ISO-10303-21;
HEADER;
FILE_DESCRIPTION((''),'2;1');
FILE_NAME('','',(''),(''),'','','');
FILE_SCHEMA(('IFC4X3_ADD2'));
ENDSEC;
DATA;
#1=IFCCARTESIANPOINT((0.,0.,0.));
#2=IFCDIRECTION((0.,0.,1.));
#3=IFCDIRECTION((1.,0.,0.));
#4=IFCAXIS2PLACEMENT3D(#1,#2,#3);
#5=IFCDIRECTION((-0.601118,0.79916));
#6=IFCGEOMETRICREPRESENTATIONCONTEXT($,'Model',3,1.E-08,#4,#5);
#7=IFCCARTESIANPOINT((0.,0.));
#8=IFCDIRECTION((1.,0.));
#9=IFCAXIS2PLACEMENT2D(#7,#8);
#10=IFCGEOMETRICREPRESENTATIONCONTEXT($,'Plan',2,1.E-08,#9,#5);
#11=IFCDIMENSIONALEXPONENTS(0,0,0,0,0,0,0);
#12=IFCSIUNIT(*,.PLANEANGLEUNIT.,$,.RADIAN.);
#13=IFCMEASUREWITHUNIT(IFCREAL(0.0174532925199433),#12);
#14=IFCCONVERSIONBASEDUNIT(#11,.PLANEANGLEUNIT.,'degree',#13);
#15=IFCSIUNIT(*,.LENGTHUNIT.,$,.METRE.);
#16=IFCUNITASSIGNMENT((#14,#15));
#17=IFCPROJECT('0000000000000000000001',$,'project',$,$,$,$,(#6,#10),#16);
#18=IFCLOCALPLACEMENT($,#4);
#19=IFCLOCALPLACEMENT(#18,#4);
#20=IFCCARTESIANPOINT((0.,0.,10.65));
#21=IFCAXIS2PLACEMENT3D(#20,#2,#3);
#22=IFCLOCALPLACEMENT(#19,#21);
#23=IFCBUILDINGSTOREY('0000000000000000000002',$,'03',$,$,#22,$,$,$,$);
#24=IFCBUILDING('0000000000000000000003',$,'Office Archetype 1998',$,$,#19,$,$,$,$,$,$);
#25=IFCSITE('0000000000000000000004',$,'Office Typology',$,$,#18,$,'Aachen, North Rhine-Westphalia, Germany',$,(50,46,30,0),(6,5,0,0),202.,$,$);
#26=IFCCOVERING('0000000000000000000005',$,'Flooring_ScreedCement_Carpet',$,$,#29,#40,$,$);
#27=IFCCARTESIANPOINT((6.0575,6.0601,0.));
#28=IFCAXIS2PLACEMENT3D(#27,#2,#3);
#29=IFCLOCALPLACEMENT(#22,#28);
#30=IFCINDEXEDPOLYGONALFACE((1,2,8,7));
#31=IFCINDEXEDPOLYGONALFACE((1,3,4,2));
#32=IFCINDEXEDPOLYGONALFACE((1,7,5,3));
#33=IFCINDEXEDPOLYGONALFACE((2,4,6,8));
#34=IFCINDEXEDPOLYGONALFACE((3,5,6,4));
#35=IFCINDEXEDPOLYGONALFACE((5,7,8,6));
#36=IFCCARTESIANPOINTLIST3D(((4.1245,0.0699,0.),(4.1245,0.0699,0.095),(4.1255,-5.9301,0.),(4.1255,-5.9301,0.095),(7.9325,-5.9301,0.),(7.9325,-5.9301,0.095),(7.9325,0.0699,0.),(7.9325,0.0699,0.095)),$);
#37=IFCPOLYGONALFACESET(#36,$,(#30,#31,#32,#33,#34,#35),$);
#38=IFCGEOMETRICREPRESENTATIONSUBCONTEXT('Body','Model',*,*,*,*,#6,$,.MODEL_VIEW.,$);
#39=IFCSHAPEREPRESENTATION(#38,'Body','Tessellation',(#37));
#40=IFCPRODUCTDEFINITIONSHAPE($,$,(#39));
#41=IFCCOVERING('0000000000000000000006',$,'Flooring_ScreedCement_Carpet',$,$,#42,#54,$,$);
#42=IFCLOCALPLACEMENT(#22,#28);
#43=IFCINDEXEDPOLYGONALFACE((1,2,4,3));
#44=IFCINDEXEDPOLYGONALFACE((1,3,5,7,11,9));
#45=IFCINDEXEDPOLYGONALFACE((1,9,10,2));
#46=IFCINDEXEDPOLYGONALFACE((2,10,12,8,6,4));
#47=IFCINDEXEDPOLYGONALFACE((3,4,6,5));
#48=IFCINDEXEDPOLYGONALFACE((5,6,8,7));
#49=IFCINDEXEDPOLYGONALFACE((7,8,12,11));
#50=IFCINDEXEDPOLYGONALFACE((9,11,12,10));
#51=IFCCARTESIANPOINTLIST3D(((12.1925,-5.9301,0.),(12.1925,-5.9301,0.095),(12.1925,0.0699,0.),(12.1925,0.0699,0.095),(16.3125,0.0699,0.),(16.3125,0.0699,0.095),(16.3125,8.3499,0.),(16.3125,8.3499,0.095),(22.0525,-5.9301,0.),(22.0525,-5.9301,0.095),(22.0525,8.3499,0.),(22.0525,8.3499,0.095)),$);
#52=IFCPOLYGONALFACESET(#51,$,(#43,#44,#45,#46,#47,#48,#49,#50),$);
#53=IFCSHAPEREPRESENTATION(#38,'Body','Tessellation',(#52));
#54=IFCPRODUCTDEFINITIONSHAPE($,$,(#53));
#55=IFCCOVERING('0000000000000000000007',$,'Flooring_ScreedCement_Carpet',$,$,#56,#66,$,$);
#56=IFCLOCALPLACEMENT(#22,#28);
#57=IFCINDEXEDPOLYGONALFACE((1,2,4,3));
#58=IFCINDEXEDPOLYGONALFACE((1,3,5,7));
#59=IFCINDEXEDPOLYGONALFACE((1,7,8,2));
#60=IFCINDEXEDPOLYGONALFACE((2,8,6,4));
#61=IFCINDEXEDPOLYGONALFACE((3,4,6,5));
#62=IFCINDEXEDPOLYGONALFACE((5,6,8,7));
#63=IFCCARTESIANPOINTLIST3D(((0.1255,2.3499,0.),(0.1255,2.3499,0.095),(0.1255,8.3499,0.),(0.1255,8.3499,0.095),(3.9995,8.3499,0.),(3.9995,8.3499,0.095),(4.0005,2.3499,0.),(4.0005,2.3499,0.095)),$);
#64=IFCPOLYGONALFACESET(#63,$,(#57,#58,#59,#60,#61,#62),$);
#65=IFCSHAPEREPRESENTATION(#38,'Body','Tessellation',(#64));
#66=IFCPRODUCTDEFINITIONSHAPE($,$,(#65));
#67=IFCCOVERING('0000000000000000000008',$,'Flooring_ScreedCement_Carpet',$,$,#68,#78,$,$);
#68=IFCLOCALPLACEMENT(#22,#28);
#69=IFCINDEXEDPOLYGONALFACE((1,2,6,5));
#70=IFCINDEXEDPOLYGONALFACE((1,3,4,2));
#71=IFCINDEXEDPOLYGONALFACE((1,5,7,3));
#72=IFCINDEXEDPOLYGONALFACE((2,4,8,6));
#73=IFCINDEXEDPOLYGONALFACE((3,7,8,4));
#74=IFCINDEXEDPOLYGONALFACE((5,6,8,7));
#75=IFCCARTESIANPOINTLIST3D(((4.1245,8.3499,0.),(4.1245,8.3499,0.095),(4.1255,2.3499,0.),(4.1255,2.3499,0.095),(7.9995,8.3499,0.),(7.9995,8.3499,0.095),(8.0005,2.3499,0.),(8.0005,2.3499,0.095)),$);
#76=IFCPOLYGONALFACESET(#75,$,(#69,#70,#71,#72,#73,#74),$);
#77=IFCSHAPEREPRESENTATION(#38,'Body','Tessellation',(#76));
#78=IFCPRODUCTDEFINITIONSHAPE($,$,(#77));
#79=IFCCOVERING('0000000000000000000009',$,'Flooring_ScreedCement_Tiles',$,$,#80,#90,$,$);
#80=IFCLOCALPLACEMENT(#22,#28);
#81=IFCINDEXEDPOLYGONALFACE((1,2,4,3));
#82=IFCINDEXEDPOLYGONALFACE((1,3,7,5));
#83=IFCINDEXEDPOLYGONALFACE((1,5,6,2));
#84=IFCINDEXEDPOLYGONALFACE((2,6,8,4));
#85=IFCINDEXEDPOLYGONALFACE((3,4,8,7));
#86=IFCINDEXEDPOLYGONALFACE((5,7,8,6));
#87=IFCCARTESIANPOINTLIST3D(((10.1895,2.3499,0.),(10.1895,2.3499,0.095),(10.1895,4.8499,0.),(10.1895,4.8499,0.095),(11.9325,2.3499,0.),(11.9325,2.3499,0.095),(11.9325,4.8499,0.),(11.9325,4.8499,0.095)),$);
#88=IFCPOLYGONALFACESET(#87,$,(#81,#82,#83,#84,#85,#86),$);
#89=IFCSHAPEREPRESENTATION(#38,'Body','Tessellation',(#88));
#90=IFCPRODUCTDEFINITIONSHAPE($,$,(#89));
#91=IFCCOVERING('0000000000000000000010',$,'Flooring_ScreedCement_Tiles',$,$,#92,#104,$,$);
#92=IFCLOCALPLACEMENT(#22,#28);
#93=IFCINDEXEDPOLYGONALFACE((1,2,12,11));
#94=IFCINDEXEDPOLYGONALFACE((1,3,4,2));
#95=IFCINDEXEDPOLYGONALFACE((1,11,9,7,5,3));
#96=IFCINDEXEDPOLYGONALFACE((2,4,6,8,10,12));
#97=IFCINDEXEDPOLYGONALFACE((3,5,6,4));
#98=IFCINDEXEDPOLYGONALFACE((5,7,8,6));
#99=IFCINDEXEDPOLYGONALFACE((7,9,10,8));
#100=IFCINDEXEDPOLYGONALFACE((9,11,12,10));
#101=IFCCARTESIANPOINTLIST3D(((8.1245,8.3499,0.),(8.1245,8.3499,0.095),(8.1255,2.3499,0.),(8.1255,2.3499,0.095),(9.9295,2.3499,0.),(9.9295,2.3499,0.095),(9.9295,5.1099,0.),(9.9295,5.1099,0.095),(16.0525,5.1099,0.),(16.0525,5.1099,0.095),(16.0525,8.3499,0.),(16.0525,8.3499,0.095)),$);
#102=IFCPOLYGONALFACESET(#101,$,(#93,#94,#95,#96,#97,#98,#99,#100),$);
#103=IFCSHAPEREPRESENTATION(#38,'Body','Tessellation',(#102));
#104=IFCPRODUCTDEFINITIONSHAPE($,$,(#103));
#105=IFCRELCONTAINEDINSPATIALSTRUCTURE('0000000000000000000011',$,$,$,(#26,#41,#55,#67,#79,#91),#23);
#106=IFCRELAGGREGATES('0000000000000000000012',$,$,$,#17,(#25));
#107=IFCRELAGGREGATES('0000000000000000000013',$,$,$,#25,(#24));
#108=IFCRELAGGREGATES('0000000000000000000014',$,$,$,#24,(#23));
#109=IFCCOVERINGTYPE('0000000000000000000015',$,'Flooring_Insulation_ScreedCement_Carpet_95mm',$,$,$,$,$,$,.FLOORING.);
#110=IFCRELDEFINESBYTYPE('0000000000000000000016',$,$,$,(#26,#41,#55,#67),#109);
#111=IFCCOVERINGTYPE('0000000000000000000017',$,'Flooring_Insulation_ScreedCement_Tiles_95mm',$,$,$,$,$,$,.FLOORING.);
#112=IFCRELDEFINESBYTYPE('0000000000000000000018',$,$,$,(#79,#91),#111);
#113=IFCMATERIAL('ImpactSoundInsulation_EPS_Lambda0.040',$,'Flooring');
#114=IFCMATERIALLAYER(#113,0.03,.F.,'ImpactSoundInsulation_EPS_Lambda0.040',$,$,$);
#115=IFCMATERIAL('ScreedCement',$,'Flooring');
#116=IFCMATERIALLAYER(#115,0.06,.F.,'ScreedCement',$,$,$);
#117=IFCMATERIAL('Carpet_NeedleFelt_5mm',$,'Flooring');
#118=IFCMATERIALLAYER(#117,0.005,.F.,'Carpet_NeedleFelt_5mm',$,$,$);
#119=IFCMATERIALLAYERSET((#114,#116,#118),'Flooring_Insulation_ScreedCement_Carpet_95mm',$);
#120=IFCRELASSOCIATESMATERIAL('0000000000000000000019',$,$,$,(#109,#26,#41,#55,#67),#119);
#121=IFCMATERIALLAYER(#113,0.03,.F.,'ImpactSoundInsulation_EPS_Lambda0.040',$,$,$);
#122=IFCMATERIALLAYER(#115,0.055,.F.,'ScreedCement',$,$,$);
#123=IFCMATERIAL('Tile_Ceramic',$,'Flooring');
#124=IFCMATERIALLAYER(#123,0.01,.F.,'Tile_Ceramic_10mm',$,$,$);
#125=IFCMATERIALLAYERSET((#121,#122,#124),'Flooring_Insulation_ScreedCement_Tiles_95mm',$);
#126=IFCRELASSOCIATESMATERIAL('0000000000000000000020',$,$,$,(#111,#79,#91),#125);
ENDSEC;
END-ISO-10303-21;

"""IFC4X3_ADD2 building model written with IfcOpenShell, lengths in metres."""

from ifc_helpers import new_model, entity, si_unit, converted_unit, direction, frame, origin_with_axes, origin_2d_with_axis, place, context, subcontext, project, spatial, line, indexed_curve, outline, extrude, material, layer, layer_set, layer_usage, type_object, element, save


model = new_model("IFC4X3_ADD2")

# Units and contexts
model_context = context("Model", 3, precision=1e-08, world=origin_with_axes(), true_north=direction((-0.601118, 0.79916)))
plan_context = context("Plan", 2, precision=1e-08, world=origin_2d_with_axis(), true_north=direction((-0.601118, 0.79916)))
body_context = subcontext(model_context, "Body", "Model", "MODEL_VIEW")
ifc_project = project(units=[converted_unit("PLANEANGLEUNIT", "degree", entity("IfcReal", 0.0174532925199433), si_unit("PLANEANGLEUNIT", "RADIAN"), dimensions=[0, 0, 0, 0, 0, 0, 0]), si_unit("LENGTHUNIT", "METRE")], contexts=[model_context, plan_context])

# Site, building, storey
site_placement = place(None, origin_with_axes())
site = spatial("IfcSite", under=ifc_project, at=site_placement, Name="Office Typology", LongName="Aachen, North Rhine-Westphalia, Germany", RefLatitude=(50, 46, 30, 0), RefLongitude=(6, 5, 0, 0), RefElevation=202.0)
building_placement = place(site_placement, origin_with_axes())
building = spatial("IfcBuilding", under=site, at=building_placement, Name="Office Archetype 1998")
storey_placement = place(building_placement, frame((0.0, 0.0, 10.65), z_axis=(0.0, 0.0, 1.0), x_axis=(1.0, 0.0, 0.0)))
storey = spatial("IfcBuildingStorey", under=building, at=storey_placement, Name="03")

# Coverings
ifc_material_1 = material(Name="ImpactSoundInsulation_EPS_Lambda0.040", Category="Flooring")
ifc_layer_1 = layer(ifc_material_1, 0.03, ventilated=False, Name="ImpactSoundInsulation_EPS_Lambda0.040")
ifc_material_2 = material(Name="ScreedCement", Category="Flooring")
ifc_layer_2 = layer(ifc_material_2, 0.06, ventilated=False, Name="ScreedCement")
ifc_material_3 = material(Name="Carpet_NeedleFelt_5mm", Category="Flooring")
ifc_layer_3 = layer(ifc_material_3, 0.005, ventilated=False, Name="Carpet_NeedleFelt_5mm")
ifc_layer_set_1 = layer_set([ifc_layer_1, ifc_layer_2, ifc_layer_3], Name="Flooring_Insulation_ScreedCement_Carpet_95mm")
ifc_layer_usage_1 = layer_usage(ifc_layer_set_1, "AXIS3", "POSITIVE", 0.0)
covering_type_1 = type_object("IfcCoveringType", Name="Flooring_Insulation_ScreedCement_Carpet_95mm", PredefinedType="FLOORING", material=ifc_layer_set_1)
covering_1_placement = place(storey_placement, frame((6.0575, 6.0601, 0.0), z_axis=(0.0, 0.0, 1.0), x_axis=(1.0, 0.0, 0.0)))
element("IfcCovering", 1, at=covering_1_placement, inside=storey, type_object=covering_type_1, material=ifc_layer_usage_1, Name="Flooring_ScreedCement_Carpet", context=body_context, shape_type="SweptSolid", body=[
    extrude(outline(indexed_curve([(4.1245, 0.0699), (7.9325, 0.0699), (7.9325, -5.9301), (4.1255, -5.9301)], segments=[line(1, 2, 3, 4, 1)])), origin_with_axes(), (0.0, 0.0, 1.0), 0.095),
])
ifc_layer_usage_2 = layer_usage(ifc_layer_set_1, "AXIS3", "POSITIVE", 0.0)
covering_2_placement = place(storey_placement, frame((6.0575, 6.0601, 0.0), z_axis=(0.0, 0.0, 1.0), x_axis=(1.0, 0.0, 0.0)))
element("IfcCovering", 2, at=covering_2_placement, inside=storey, type_object=covering_type_1, material=ifc_layer_usage_2, Name="Flooring_ScreedCement_Carpet", context=body_context, shape_type="SweptSolid", body=[
    extrude(outline(indexed_curve([(16.3125, 8.3499), (22.0525, 8.3499), (22.0525, -5.9301), (12.1925, -5.9301), (12.1925, 0.0699), (16.3125, 0.0699)], segments=[line(1, 2, 3, 4, 5, 6, 1)])), origin_with_axes(), (0.0, 0.0, 1.0), 0.095),
])
ifc_layer_usage_3 = layer_usage(ifc_layer_set_1, "AXIS3", "POSITIVE", 0.0)
covering_3_placement = place(storey_placement, frame((6.0575, 6.0601, 0.0), z_axis=(0.0, 0.0, 1.0), x_axis=(1.0, 0.0, 0.0)))
element("IfcCovering", 3, at=covering_3_placement, inside=storey, type_object=covering_type_1, material=ifc_layer_usage_3, Name="Flooring_ScreedCement_Carpet", context=body_context, shape_type="SweptSolid", body=[
    extrude(outline(indexed_curve([(0.1255, 2.3499), (0.1255, 8.3499), (3.9995, 8.3499), (4.0005, 2.3499)], segments=[line(1, 2, 3, 4, 1)])), origin_with_axes(), (0.0, 0.0, 1.0), 0.095),
])
ifc_layer_usage_4 = layer_usage(ifc_layer_set_1, "AXIS3", "POSITIVE", 0.0)
covering_4_placement = place(storey_placement, frame((6.0575, 6.0601, 0.0), z_axis=(0.0, 0.0, 1.0), x_axis=(1.0, 0.0, 0.0)))
element("IfcCovering", 4, at=covering_4_placement, inside=storey, type_object=covering_type_1, material=ifc_layer_usage_4, Name="Flooring_ScreedCement_Carpet", context=body_context, shape_type="SweptSolid", body=[
    extrude(outline(indexed_curve([(4.1255, 2.3499), (4.1245, 8.3499), (7.9995, 8.3499), (8.0005, 2.3499)], segments=[line(1, 2, 3, 4, 1)])), origin_with_axes(), (0.0, 0.0, 1.0), 0.095),
])
ifc_layer_4 = layer(ifc_material_1, 0.03, ventilated=False, Name="ImpactSoundInsulation_EPS_Lambda0.040")
ifc_layer_5 = layer(ifc_material_2, 0.055, ventilated=False, Name="ScreedCement")
ifc_material_4 = material(Name="Tile_Ceramic", Category="Flooring")
ifc_layer_6 = layer(ifc_material_4, 0.01, ventilated=False, Name="Tile_Ceramic_10mm")
ifc_layer_set_2 = layer_set([ifc_layer_4, ifc_layer_5, ifc_layer_6], Name="Flooring_Insulation_ScreedCement_Tiles_95mm")
ifc_layer_usage_5 = layer_usage(ifc_layer_set_2, "AXIS3", "POSITIVE", 0.0)
covering_type_2 = type_object("IfcCoveringType", Name="Flooring_Insulation_ScreedCement_Tiles_95mm", PredefinedType="FLOORING", material=ifc_layer_set_2)
covering_5_placement = place(storey_placement, frame((6.0575, 6.0601, 0.0), z_axis=(0.0, 0.0, 1.0), x_axis=(1.0, 0.0, 0.0)))
element("IfcCovering", 5, at=covering_5_placement, inside=storey, type_object=covering_type_2, material=ifc_layer_usage_5, Name="Flooring_ScreedCement_Tiles", context=body_context, shape_type="SweptSolid", body=[
    extrude(outline(indexed_curve([(11.9325, 4.8499), (11.9325, 2.3499), (10.1895, 2.3499), (10.1895, 4.8499)], segments=[line(1, 2, 3, 4, 1)])), None, (0.0, 0.0, 1.0), 0.095),
])
ifc_layer_usage_6 = layer_usage(ifc_layer_set_2, "AXIS3", "POSITIVE", 0.0)
covering_6_placement = place(storey_placement, frame((6.0575, 6.0601, 0.0), z_axis=(0.0, 0.0, 1.0), x_axis=(1.0, 0.0, 0.0)))
element("IfcCovering", 6, at=covering_6_placement, inside=storey, type_object=covering_type_2, material=ifc_layer_usage_6, Name="Flooring_ScreedCement_Tiles", context=body_context, shape_type="SweptSolid", body=[
    extrude(outline(indexed_curve([(9.9295, 5.1099), (9.9295, 2.3499), (8.1255, 2.3499), (8.1245, 8.3499), (16.0525, 8.3499), (16.0525, 5.1099)], segments=[line(1, 2, 3, 4, 5, 6, 1)])), None, (0.0, 0.0, 1.0), 0.095),
])

save(model, "model.ifc")
